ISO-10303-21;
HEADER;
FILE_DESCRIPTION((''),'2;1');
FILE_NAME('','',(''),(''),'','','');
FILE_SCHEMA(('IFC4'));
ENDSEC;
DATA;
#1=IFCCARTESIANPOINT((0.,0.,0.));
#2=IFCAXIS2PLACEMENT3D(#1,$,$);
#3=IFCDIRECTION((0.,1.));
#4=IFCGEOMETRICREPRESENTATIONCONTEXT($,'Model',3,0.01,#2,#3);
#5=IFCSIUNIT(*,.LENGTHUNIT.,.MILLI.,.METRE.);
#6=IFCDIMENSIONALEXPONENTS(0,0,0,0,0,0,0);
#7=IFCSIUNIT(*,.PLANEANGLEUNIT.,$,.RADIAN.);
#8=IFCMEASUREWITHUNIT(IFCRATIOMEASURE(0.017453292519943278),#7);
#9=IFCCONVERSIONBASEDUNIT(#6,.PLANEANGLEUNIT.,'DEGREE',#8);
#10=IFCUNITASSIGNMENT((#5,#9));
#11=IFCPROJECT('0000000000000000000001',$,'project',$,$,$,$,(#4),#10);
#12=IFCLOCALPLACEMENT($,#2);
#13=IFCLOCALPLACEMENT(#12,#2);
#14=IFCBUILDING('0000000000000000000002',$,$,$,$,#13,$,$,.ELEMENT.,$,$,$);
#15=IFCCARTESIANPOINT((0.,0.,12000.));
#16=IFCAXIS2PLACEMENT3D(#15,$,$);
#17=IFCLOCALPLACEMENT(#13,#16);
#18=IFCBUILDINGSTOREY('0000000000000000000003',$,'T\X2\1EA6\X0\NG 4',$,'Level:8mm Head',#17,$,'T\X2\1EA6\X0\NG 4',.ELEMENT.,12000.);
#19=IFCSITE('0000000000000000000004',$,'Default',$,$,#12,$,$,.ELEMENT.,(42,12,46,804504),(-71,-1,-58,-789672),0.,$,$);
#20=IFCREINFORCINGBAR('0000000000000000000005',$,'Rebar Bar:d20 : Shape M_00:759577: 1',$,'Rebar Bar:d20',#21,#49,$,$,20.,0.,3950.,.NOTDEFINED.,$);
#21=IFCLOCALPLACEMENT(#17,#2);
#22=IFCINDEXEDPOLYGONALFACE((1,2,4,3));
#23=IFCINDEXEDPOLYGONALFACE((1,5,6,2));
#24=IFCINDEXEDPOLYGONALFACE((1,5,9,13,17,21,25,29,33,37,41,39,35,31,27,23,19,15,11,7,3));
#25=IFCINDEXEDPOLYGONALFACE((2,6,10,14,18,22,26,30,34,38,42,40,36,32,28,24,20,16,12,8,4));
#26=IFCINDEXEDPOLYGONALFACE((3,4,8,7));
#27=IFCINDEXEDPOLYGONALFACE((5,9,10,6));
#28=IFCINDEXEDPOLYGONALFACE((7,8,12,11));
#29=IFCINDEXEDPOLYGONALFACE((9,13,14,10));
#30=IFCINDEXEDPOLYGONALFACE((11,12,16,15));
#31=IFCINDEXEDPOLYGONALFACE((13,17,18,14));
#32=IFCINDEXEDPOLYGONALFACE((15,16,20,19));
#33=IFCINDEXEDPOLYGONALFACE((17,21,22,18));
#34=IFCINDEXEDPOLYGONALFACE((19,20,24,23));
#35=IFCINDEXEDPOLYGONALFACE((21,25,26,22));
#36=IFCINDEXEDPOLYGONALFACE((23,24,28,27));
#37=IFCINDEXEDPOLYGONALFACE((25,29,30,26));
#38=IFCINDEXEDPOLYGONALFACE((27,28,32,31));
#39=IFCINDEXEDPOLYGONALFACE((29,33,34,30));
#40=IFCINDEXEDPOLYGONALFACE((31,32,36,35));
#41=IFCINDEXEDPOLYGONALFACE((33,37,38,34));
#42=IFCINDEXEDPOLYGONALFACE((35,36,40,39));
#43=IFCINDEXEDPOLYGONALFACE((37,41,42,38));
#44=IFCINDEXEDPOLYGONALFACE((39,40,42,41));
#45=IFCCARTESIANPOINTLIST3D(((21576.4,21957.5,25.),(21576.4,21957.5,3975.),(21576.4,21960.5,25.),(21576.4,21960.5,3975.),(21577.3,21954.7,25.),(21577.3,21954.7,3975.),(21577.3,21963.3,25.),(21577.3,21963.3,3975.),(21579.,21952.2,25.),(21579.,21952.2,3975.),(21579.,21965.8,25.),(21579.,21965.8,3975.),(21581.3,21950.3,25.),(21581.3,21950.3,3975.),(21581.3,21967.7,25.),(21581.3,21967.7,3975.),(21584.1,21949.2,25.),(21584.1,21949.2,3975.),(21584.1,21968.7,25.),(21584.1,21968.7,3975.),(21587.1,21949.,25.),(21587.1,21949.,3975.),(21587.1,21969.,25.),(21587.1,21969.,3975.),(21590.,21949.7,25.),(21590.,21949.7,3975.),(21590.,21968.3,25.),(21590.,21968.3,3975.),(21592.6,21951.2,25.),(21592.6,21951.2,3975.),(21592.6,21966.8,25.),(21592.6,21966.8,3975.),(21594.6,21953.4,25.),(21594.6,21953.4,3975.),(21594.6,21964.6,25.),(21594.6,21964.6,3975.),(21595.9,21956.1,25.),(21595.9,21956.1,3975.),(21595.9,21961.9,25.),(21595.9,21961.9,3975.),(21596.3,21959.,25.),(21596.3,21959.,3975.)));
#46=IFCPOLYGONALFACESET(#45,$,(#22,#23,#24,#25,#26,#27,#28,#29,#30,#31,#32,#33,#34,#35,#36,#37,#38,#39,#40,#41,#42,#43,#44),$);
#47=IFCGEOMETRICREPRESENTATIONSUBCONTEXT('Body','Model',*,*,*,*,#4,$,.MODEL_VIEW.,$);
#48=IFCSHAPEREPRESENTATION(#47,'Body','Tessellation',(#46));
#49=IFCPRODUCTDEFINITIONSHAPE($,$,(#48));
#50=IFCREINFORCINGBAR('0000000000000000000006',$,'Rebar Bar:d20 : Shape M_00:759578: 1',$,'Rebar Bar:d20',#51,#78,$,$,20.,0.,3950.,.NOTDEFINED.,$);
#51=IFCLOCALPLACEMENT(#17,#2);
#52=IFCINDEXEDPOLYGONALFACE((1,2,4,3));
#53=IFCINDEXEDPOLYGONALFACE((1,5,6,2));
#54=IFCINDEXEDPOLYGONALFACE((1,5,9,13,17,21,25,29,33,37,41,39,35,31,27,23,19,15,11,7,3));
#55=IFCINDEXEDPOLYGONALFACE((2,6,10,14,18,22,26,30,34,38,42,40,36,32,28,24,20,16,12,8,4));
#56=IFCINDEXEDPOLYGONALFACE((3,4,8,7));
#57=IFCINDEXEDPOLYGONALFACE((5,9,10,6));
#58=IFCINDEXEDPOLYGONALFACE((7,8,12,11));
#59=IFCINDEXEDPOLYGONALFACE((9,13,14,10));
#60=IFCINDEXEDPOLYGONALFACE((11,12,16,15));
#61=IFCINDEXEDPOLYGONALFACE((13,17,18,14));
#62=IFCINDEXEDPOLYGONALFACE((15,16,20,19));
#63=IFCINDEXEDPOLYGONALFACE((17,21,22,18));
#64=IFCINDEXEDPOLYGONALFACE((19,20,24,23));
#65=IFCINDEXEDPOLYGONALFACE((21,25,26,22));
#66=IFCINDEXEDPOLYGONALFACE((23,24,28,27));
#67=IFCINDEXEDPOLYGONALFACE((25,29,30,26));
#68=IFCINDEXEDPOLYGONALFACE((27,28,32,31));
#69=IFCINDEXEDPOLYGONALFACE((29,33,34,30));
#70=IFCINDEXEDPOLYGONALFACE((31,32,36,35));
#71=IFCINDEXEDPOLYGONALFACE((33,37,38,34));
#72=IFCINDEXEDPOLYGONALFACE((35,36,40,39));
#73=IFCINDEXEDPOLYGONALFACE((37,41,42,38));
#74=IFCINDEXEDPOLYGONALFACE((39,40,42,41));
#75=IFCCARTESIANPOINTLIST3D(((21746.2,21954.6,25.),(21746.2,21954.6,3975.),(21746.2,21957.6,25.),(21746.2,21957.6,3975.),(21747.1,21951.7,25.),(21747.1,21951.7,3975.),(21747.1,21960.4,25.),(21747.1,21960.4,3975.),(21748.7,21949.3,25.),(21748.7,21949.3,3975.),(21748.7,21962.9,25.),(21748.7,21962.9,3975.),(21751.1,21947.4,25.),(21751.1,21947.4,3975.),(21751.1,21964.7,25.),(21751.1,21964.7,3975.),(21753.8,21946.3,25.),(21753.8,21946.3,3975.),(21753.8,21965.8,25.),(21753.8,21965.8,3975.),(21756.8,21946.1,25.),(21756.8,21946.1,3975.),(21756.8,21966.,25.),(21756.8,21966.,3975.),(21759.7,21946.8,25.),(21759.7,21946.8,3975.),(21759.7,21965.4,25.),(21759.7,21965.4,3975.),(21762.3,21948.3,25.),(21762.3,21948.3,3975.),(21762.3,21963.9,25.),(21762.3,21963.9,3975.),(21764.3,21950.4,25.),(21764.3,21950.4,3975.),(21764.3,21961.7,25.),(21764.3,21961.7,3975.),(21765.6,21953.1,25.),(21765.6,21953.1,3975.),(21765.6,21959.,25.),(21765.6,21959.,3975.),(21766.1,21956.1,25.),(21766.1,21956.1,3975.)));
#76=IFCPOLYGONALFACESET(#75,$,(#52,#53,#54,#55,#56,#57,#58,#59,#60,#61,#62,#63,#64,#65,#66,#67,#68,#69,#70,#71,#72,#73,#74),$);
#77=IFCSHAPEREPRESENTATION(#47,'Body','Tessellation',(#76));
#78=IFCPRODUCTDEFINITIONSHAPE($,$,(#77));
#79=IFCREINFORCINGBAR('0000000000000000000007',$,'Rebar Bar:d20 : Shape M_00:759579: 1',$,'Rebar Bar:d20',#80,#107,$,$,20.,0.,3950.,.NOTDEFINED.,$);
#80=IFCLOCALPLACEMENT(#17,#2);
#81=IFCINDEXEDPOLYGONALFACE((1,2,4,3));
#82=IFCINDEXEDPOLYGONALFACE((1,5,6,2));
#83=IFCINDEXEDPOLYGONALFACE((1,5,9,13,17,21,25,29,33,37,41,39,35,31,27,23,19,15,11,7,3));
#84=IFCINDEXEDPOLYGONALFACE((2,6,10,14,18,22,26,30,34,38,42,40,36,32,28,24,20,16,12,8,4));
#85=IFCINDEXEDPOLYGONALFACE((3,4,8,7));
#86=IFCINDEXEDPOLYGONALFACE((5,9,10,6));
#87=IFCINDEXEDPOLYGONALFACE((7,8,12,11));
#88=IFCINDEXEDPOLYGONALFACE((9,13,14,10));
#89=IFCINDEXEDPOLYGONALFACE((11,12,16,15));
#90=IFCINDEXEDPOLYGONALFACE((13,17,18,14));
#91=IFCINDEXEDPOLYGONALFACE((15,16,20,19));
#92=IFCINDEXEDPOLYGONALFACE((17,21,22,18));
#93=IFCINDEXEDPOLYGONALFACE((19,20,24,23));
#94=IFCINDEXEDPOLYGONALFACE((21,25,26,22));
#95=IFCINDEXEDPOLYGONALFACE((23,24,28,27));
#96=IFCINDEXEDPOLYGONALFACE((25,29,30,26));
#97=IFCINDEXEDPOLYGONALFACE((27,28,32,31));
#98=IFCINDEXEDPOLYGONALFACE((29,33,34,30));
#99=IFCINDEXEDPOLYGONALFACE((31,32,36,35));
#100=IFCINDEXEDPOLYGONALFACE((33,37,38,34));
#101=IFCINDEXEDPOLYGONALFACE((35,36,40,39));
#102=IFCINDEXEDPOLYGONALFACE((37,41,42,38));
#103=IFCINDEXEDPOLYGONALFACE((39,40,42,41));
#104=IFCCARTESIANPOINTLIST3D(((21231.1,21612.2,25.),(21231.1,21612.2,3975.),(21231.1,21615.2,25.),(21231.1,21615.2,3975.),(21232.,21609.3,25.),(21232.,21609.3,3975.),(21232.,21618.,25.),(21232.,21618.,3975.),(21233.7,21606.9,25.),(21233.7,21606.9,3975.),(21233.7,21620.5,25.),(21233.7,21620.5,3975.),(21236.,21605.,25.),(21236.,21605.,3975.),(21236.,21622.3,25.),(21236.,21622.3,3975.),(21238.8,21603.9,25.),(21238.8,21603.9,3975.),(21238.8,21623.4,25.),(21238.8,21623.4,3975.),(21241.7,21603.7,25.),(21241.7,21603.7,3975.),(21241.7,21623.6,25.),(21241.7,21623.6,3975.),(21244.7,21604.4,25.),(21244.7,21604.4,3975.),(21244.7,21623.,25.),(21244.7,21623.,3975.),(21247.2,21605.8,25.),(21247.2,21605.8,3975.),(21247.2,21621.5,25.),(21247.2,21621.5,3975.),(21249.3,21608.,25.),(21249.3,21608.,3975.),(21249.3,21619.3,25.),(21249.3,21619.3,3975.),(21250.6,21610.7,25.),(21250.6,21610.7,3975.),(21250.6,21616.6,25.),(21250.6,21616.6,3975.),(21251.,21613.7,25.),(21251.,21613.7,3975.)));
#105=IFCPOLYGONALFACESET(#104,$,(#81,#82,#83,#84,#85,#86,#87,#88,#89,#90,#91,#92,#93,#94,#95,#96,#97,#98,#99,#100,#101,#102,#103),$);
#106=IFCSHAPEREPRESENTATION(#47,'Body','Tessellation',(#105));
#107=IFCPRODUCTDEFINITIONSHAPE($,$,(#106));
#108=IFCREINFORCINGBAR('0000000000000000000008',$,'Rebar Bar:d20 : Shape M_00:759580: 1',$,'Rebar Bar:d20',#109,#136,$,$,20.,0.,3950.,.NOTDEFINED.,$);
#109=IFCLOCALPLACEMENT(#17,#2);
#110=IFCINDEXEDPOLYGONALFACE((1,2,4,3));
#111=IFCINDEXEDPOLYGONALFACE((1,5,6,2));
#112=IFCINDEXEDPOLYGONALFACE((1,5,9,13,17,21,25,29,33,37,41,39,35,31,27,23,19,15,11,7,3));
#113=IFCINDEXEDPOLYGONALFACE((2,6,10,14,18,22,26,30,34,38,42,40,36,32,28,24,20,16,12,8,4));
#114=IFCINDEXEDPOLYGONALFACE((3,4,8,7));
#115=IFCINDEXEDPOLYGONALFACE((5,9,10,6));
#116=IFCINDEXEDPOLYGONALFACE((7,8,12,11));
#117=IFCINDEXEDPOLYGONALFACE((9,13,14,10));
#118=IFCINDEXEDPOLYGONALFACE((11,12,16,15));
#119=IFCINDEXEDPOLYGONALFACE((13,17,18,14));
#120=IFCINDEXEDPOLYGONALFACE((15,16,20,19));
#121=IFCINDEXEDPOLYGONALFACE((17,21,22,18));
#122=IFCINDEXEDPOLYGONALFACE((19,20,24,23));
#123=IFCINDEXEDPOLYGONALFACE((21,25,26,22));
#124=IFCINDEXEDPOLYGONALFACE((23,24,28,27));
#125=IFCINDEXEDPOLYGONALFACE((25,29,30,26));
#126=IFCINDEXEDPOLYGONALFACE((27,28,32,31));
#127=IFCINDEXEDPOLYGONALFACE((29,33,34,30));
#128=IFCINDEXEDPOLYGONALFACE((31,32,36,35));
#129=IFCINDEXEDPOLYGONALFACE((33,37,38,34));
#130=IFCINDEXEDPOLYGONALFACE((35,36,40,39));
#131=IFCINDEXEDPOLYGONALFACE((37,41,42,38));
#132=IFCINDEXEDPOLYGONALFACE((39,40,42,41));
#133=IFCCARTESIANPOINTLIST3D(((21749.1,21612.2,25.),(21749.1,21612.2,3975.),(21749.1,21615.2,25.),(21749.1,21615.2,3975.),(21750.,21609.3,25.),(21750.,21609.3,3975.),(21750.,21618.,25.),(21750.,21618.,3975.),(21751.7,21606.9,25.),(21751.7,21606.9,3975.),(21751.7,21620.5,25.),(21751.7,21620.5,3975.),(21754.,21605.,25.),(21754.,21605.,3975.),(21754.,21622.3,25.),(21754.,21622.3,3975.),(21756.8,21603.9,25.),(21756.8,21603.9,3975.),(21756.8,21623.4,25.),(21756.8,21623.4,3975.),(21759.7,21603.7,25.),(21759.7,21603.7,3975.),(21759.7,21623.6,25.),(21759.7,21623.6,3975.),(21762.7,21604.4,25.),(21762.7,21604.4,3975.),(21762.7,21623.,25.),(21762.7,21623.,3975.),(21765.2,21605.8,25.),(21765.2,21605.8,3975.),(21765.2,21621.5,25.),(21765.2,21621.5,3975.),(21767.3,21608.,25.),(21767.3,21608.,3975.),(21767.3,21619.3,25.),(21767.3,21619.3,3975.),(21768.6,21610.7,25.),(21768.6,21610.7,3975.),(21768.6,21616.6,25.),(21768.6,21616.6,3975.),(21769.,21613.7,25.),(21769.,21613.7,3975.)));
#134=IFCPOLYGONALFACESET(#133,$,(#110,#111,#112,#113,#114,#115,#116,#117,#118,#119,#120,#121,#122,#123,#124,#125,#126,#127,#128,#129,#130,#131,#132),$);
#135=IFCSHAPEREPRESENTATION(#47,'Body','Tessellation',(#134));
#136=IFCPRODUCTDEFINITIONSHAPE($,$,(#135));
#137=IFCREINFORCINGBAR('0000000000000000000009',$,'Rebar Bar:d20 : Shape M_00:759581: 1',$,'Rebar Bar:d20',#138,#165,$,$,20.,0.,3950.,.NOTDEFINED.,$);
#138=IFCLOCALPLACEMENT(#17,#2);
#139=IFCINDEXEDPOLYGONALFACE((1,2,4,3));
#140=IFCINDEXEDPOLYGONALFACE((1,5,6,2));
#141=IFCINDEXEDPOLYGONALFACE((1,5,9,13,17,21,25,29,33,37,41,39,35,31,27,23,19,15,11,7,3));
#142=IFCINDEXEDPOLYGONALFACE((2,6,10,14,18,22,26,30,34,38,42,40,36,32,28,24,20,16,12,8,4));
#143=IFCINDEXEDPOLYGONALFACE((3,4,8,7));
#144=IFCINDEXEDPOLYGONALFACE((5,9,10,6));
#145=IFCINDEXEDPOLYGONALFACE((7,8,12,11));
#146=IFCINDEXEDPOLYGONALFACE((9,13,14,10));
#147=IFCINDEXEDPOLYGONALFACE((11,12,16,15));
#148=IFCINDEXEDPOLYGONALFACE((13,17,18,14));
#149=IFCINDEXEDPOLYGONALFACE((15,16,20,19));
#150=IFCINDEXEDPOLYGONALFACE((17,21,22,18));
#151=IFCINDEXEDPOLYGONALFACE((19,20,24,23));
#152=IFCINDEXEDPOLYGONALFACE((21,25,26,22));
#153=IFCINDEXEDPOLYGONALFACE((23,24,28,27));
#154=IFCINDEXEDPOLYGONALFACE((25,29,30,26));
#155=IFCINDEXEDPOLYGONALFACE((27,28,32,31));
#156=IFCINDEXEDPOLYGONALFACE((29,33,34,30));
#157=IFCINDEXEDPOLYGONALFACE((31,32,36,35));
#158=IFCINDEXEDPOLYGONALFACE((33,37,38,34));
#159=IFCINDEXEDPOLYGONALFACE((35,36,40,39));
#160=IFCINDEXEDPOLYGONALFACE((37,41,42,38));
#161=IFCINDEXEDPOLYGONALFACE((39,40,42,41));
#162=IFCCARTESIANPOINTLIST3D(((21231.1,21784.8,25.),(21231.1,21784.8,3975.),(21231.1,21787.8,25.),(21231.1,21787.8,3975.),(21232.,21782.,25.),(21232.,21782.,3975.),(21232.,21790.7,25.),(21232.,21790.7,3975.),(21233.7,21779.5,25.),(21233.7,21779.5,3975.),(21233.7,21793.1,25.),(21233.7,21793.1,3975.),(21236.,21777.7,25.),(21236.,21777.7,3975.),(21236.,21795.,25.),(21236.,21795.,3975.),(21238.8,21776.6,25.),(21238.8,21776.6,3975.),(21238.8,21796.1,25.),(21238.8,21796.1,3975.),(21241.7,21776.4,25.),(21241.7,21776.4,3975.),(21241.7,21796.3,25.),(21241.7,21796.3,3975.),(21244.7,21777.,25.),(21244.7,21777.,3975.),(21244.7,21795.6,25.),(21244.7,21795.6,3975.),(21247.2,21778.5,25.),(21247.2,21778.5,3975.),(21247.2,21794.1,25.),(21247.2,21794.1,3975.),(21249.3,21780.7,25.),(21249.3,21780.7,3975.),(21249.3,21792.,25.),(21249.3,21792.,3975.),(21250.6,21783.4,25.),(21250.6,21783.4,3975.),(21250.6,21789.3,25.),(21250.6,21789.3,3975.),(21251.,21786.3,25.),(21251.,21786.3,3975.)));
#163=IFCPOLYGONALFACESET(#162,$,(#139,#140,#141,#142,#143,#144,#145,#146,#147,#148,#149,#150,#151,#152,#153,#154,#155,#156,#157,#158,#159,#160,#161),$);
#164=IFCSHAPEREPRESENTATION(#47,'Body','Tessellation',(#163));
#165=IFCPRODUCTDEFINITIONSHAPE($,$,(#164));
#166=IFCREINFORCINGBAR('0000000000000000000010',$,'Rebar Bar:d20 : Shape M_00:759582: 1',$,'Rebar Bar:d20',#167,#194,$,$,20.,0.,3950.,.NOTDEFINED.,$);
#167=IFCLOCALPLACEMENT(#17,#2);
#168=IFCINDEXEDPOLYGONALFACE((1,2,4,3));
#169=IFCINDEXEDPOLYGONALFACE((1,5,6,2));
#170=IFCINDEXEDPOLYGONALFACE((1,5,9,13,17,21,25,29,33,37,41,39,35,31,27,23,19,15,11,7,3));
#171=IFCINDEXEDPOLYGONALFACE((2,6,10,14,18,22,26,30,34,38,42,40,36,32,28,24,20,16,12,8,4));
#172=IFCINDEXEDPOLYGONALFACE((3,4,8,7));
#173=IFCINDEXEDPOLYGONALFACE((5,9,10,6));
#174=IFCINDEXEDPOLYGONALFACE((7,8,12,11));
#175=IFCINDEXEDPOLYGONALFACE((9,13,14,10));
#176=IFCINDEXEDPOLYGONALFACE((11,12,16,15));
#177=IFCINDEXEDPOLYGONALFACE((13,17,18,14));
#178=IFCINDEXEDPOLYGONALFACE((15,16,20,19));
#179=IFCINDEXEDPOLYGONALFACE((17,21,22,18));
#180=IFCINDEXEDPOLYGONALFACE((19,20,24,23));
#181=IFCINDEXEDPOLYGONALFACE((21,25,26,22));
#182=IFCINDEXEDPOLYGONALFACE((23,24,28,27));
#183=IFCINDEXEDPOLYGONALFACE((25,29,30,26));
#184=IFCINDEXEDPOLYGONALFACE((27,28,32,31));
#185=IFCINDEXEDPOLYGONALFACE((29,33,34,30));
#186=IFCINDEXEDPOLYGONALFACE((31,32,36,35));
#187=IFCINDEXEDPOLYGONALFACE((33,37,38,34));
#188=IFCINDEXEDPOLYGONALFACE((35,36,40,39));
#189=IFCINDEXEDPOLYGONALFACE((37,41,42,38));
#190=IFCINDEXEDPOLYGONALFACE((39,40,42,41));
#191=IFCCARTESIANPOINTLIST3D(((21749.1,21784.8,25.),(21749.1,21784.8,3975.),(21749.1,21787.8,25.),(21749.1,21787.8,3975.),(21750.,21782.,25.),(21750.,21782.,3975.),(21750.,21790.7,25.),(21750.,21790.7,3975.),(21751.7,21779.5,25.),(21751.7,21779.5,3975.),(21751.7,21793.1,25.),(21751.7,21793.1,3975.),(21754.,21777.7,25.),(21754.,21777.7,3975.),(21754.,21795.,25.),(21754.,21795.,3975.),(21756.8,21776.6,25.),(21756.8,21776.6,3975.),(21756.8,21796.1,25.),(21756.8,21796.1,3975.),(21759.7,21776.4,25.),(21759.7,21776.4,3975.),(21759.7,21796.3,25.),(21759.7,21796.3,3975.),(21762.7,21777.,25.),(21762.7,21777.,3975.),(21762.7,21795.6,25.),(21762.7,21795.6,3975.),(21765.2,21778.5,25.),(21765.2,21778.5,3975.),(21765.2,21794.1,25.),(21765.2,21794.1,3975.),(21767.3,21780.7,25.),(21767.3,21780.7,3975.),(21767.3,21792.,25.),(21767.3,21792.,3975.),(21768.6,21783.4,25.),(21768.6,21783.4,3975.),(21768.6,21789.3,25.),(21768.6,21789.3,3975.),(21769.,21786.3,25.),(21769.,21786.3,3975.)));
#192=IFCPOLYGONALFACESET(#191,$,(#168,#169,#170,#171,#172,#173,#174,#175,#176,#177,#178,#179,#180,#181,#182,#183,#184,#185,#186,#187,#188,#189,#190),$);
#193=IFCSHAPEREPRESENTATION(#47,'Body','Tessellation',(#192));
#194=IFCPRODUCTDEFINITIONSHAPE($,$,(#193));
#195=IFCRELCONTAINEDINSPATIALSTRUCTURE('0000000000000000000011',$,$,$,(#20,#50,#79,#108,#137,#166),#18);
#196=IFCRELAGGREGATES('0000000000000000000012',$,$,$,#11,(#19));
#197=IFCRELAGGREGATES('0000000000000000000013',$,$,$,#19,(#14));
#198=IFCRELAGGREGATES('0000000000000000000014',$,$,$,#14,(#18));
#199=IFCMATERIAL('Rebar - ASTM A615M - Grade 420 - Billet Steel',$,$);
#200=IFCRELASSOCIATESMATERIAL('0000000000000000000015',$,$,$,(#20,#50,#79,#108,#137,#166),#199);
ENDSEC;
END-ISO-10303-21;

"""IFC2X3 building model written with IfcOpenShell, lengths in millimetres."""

from ifc_helpers import new_model, entity, si_unit, converted_unit, direction, frame, origin, place, context, subcontext, project, spatial, material, element, save


model = new_model("IFC2X3")

# Units and contexts
model_context = context("Model", 3, precision=0.01, world=origin(), true_north=direction((0.0, 1.0)))
body_context = subcontext(model_context, "Body", "Model", "MODEL_VIEW")
ifc_project = project(units=[si_unit("LENGTHUNIT", "METRE", prefix="MILLI"), converted_unit("PLANEANGLEUNIT", "DEGREE", entity("IfcRatioMeasure", 0.017453292519943278), si_unit("PLANEANGLEUNIT", "RADIAN"), dimensions=[0, 0, 0, 0, 0, 0, 0])], contexts=[model_context])

# Site, building, storey
site_placement = place(None, origin())
site = spatial("IfcSite", under=ifc_project, at=site_placement, Name="Default", CompositionType="ELEMENT", RefLatitude=(42, 12, 46, 804504), RefLongitude=(-71, -1, -58, -789672), RefElevation=0.0)
building_placement = place(site_placement, origin())
building = spatial("IfcBuilding", under=site, at=building_placement, CompositionType="ELEMENT")
storey_placement = place(building_placement, frame((0.0, 0.0, 12000.0)))
storey = spatial("IfcBuildingStorey", under=building, at=storey_placement, Name="TẦNG 4", ObjectType="Level:8mm Head", LongName="TẦNG 4", CompositionType="ELEMENT", Elevation=12000.0)

# Reinforcing bars
ifc_material = material(Name="Rebar - ASTM A615M - Grade 420 - Billet Steel")
reinforcing_bar_1_placement = place(storey_placement, origin())
element("IfcReinforcingBar", 1, at=reinforcing_bar_1_placement, inside=storey, material=ifc_material, Name="Rebar Bar:d20 : Shape M_00:759577: 1", ObjectType="Rebar Bar:d20", BarLength=3950.0, BarRole="NOTDEFINED", CrossSectionArea=0.0, NominalDiameter=20.0, context=body_context, shape_type="AdvancedSweptSolid", body=[
    entity("IfcSweptDiskSolid", entity("IfcCompositeCurve", [entity("IfcCompositeCurveSegment", "CONTINUOUS", True, entity("IfcPolyline", [entity("IfcCartesianPoint", [21586.3, 21959.0, 25.0]), entity("IfcCartesianPoint", [21586.3, 21959.0, 3975.0])]))], False), 10.0, None, 0.0, 1.0),
])
reinforcing_bar_2_placement = place(storey_placement, origin())
element("IfcReinforcingBar", 2, at=reinforcing_bar_2_placement, inside=storey, material=ifc_material, Name="Rebar Bar:d20 : Shape M_00:759578: 1", ObjectType="Rebar Bar:d20", BarLength=3950.0, BarRole="NOTDEFINED", CrossSectionArea=0.0, NominalDiameter=20.0, context=body_context, shape_type="AdvancedSweptSolid", body=[
    entity("IfcSweptDiskSolid", entity("IfcCompositeCurve", [entity("IfcCompositeCurveSegment", "CONTINUOUS", True, entity("IfcPolyline", [entity("IfcCartesianPoint", [21756.1, 21956.1, 25.0]), entity("IfcCartesianPoint", [21756.1, 21956.1, 3975.0])]))], False), 10.0, None, 0.0, 1.0),
])
reinforcing_bar_3_placement = place(storey_placement, origin())
element("IfcReinforcingBar", 3, at=reinforcing_bar_3_placement, inside=storey, material=ifc_material, Name="Rebar Bar:d20 : Shape M_00:759579: 1", ObjectType="Rebar Bar:d20", BarLength=3950.0, BarRole="NOTDEFINED", CrossSectionArea=0.0, NominalDiameter=20.0, context=body_context, shape_type="AdvancedSweptSolid", body=[
    entity("IfcSweptDiskSolid", entity("IfcCompositeCurve", [entity("IfcCompositeCurveSegment", "CONTINUOUS", True, entity("IfcPolyline", [entity("IfcCartesianPoint", [21241.0, 21613.7, 25.0]), entity("IfcCartesianPoint", [21241.0, 21613.7, 3975.0])]))], False), 10.0, None, 0.0, 1.0),
])
reinforcing_bar_4_placement = place(storey_placement, origin())
element("IfcReinforcingBar", 4, at=reinforcing_bar_4_placement, inside=storey, material=ifc_material, Name="Rebar Bar:d20 : Shape M_00:759580: 1", ObjectType="Rebar Bar:d20", BarLength=3950.0, BarRole="NOTDEFINED", CrossSectionArea=0.0, NominalDiameter=20.0, context=body_context, shape_type="AdvancedSweptSolid", body=[
    entity("IfcSweptDiskSolid", entity("IfcCompositeCurve", [entity("IfcCompositeCurveSegment", "CONTINUOUS", True, entity("IfcPolyline", [entity("IfcCartesianPoint", [21759.0, 21613.7, 25.0]), entity("IfcCartesianPoint", [21759.0, 21613.7, 3975.0])]))], False), 10.0, None, 0.0, 1.0),
])
reinforcing_bar_5_placement = place(storey_placement, origin())
element("IfcReinforcingBar", 5, at=reinforcing_bar_5_placement, inside=storey, material=ifc_material, Name="Rebar Bar:d20 : Shape M_00:759581: 1", ObjectType="Rebar Bar:d20", BarLength=3950.0, BarRole="NOTDEFINED", CrossSectionArea=0.0, NominalDiameter=20.0, context=body_context, shape_type="AdvancedSweptSolid", body=[
    entity("IfcSweptDiskSolid", entity("IfcCompositeCurve", [entity("IfcCompositeCurveSegment", "CONTINUOUS", True, entity("IfcPolyline", [entity("IfcCartesianPoint", [21241.0, 21786.3, 25.0]), entity("IfcCartesianPoint", [21241.0, 21786.3, 3975.0])]))], False), 10.0, None, 0.0, 1.0),
])
reinforcing_bar_6_placement = place(storey_placement, origin())
element("IfcReinforcingBar", 6, at=reinforcing_bar_6_placement, inside=storey, material=ifc_material, Name="Rebar Bar:d20 : Shape M_00:759582: 1", ObjectType="Rebar Bar:d20", BarLength=3950.0, BarRole="NOTDEFINED", CrossSectionArea=0.0, NominalDiameter=20.0, context=body_context, shape_type="AdvancedSweptSolid", body=[
    entity("IfcSweptDiskSolid", entity("IfcCompositeCurve", [entity("IfcCompositeCurveSegment", "CONTINUOUS", True, entity("IfcPolyline", [entity("IfcCartesianPoint", [21759.0, 21786.3, 25.0]), entity("IfcCartesianPoint", [21759.0, 21786.3, 3975.0])]))], False), 10.0, None, 0.0, 1.0),
])

save(model, "model.ifc")
